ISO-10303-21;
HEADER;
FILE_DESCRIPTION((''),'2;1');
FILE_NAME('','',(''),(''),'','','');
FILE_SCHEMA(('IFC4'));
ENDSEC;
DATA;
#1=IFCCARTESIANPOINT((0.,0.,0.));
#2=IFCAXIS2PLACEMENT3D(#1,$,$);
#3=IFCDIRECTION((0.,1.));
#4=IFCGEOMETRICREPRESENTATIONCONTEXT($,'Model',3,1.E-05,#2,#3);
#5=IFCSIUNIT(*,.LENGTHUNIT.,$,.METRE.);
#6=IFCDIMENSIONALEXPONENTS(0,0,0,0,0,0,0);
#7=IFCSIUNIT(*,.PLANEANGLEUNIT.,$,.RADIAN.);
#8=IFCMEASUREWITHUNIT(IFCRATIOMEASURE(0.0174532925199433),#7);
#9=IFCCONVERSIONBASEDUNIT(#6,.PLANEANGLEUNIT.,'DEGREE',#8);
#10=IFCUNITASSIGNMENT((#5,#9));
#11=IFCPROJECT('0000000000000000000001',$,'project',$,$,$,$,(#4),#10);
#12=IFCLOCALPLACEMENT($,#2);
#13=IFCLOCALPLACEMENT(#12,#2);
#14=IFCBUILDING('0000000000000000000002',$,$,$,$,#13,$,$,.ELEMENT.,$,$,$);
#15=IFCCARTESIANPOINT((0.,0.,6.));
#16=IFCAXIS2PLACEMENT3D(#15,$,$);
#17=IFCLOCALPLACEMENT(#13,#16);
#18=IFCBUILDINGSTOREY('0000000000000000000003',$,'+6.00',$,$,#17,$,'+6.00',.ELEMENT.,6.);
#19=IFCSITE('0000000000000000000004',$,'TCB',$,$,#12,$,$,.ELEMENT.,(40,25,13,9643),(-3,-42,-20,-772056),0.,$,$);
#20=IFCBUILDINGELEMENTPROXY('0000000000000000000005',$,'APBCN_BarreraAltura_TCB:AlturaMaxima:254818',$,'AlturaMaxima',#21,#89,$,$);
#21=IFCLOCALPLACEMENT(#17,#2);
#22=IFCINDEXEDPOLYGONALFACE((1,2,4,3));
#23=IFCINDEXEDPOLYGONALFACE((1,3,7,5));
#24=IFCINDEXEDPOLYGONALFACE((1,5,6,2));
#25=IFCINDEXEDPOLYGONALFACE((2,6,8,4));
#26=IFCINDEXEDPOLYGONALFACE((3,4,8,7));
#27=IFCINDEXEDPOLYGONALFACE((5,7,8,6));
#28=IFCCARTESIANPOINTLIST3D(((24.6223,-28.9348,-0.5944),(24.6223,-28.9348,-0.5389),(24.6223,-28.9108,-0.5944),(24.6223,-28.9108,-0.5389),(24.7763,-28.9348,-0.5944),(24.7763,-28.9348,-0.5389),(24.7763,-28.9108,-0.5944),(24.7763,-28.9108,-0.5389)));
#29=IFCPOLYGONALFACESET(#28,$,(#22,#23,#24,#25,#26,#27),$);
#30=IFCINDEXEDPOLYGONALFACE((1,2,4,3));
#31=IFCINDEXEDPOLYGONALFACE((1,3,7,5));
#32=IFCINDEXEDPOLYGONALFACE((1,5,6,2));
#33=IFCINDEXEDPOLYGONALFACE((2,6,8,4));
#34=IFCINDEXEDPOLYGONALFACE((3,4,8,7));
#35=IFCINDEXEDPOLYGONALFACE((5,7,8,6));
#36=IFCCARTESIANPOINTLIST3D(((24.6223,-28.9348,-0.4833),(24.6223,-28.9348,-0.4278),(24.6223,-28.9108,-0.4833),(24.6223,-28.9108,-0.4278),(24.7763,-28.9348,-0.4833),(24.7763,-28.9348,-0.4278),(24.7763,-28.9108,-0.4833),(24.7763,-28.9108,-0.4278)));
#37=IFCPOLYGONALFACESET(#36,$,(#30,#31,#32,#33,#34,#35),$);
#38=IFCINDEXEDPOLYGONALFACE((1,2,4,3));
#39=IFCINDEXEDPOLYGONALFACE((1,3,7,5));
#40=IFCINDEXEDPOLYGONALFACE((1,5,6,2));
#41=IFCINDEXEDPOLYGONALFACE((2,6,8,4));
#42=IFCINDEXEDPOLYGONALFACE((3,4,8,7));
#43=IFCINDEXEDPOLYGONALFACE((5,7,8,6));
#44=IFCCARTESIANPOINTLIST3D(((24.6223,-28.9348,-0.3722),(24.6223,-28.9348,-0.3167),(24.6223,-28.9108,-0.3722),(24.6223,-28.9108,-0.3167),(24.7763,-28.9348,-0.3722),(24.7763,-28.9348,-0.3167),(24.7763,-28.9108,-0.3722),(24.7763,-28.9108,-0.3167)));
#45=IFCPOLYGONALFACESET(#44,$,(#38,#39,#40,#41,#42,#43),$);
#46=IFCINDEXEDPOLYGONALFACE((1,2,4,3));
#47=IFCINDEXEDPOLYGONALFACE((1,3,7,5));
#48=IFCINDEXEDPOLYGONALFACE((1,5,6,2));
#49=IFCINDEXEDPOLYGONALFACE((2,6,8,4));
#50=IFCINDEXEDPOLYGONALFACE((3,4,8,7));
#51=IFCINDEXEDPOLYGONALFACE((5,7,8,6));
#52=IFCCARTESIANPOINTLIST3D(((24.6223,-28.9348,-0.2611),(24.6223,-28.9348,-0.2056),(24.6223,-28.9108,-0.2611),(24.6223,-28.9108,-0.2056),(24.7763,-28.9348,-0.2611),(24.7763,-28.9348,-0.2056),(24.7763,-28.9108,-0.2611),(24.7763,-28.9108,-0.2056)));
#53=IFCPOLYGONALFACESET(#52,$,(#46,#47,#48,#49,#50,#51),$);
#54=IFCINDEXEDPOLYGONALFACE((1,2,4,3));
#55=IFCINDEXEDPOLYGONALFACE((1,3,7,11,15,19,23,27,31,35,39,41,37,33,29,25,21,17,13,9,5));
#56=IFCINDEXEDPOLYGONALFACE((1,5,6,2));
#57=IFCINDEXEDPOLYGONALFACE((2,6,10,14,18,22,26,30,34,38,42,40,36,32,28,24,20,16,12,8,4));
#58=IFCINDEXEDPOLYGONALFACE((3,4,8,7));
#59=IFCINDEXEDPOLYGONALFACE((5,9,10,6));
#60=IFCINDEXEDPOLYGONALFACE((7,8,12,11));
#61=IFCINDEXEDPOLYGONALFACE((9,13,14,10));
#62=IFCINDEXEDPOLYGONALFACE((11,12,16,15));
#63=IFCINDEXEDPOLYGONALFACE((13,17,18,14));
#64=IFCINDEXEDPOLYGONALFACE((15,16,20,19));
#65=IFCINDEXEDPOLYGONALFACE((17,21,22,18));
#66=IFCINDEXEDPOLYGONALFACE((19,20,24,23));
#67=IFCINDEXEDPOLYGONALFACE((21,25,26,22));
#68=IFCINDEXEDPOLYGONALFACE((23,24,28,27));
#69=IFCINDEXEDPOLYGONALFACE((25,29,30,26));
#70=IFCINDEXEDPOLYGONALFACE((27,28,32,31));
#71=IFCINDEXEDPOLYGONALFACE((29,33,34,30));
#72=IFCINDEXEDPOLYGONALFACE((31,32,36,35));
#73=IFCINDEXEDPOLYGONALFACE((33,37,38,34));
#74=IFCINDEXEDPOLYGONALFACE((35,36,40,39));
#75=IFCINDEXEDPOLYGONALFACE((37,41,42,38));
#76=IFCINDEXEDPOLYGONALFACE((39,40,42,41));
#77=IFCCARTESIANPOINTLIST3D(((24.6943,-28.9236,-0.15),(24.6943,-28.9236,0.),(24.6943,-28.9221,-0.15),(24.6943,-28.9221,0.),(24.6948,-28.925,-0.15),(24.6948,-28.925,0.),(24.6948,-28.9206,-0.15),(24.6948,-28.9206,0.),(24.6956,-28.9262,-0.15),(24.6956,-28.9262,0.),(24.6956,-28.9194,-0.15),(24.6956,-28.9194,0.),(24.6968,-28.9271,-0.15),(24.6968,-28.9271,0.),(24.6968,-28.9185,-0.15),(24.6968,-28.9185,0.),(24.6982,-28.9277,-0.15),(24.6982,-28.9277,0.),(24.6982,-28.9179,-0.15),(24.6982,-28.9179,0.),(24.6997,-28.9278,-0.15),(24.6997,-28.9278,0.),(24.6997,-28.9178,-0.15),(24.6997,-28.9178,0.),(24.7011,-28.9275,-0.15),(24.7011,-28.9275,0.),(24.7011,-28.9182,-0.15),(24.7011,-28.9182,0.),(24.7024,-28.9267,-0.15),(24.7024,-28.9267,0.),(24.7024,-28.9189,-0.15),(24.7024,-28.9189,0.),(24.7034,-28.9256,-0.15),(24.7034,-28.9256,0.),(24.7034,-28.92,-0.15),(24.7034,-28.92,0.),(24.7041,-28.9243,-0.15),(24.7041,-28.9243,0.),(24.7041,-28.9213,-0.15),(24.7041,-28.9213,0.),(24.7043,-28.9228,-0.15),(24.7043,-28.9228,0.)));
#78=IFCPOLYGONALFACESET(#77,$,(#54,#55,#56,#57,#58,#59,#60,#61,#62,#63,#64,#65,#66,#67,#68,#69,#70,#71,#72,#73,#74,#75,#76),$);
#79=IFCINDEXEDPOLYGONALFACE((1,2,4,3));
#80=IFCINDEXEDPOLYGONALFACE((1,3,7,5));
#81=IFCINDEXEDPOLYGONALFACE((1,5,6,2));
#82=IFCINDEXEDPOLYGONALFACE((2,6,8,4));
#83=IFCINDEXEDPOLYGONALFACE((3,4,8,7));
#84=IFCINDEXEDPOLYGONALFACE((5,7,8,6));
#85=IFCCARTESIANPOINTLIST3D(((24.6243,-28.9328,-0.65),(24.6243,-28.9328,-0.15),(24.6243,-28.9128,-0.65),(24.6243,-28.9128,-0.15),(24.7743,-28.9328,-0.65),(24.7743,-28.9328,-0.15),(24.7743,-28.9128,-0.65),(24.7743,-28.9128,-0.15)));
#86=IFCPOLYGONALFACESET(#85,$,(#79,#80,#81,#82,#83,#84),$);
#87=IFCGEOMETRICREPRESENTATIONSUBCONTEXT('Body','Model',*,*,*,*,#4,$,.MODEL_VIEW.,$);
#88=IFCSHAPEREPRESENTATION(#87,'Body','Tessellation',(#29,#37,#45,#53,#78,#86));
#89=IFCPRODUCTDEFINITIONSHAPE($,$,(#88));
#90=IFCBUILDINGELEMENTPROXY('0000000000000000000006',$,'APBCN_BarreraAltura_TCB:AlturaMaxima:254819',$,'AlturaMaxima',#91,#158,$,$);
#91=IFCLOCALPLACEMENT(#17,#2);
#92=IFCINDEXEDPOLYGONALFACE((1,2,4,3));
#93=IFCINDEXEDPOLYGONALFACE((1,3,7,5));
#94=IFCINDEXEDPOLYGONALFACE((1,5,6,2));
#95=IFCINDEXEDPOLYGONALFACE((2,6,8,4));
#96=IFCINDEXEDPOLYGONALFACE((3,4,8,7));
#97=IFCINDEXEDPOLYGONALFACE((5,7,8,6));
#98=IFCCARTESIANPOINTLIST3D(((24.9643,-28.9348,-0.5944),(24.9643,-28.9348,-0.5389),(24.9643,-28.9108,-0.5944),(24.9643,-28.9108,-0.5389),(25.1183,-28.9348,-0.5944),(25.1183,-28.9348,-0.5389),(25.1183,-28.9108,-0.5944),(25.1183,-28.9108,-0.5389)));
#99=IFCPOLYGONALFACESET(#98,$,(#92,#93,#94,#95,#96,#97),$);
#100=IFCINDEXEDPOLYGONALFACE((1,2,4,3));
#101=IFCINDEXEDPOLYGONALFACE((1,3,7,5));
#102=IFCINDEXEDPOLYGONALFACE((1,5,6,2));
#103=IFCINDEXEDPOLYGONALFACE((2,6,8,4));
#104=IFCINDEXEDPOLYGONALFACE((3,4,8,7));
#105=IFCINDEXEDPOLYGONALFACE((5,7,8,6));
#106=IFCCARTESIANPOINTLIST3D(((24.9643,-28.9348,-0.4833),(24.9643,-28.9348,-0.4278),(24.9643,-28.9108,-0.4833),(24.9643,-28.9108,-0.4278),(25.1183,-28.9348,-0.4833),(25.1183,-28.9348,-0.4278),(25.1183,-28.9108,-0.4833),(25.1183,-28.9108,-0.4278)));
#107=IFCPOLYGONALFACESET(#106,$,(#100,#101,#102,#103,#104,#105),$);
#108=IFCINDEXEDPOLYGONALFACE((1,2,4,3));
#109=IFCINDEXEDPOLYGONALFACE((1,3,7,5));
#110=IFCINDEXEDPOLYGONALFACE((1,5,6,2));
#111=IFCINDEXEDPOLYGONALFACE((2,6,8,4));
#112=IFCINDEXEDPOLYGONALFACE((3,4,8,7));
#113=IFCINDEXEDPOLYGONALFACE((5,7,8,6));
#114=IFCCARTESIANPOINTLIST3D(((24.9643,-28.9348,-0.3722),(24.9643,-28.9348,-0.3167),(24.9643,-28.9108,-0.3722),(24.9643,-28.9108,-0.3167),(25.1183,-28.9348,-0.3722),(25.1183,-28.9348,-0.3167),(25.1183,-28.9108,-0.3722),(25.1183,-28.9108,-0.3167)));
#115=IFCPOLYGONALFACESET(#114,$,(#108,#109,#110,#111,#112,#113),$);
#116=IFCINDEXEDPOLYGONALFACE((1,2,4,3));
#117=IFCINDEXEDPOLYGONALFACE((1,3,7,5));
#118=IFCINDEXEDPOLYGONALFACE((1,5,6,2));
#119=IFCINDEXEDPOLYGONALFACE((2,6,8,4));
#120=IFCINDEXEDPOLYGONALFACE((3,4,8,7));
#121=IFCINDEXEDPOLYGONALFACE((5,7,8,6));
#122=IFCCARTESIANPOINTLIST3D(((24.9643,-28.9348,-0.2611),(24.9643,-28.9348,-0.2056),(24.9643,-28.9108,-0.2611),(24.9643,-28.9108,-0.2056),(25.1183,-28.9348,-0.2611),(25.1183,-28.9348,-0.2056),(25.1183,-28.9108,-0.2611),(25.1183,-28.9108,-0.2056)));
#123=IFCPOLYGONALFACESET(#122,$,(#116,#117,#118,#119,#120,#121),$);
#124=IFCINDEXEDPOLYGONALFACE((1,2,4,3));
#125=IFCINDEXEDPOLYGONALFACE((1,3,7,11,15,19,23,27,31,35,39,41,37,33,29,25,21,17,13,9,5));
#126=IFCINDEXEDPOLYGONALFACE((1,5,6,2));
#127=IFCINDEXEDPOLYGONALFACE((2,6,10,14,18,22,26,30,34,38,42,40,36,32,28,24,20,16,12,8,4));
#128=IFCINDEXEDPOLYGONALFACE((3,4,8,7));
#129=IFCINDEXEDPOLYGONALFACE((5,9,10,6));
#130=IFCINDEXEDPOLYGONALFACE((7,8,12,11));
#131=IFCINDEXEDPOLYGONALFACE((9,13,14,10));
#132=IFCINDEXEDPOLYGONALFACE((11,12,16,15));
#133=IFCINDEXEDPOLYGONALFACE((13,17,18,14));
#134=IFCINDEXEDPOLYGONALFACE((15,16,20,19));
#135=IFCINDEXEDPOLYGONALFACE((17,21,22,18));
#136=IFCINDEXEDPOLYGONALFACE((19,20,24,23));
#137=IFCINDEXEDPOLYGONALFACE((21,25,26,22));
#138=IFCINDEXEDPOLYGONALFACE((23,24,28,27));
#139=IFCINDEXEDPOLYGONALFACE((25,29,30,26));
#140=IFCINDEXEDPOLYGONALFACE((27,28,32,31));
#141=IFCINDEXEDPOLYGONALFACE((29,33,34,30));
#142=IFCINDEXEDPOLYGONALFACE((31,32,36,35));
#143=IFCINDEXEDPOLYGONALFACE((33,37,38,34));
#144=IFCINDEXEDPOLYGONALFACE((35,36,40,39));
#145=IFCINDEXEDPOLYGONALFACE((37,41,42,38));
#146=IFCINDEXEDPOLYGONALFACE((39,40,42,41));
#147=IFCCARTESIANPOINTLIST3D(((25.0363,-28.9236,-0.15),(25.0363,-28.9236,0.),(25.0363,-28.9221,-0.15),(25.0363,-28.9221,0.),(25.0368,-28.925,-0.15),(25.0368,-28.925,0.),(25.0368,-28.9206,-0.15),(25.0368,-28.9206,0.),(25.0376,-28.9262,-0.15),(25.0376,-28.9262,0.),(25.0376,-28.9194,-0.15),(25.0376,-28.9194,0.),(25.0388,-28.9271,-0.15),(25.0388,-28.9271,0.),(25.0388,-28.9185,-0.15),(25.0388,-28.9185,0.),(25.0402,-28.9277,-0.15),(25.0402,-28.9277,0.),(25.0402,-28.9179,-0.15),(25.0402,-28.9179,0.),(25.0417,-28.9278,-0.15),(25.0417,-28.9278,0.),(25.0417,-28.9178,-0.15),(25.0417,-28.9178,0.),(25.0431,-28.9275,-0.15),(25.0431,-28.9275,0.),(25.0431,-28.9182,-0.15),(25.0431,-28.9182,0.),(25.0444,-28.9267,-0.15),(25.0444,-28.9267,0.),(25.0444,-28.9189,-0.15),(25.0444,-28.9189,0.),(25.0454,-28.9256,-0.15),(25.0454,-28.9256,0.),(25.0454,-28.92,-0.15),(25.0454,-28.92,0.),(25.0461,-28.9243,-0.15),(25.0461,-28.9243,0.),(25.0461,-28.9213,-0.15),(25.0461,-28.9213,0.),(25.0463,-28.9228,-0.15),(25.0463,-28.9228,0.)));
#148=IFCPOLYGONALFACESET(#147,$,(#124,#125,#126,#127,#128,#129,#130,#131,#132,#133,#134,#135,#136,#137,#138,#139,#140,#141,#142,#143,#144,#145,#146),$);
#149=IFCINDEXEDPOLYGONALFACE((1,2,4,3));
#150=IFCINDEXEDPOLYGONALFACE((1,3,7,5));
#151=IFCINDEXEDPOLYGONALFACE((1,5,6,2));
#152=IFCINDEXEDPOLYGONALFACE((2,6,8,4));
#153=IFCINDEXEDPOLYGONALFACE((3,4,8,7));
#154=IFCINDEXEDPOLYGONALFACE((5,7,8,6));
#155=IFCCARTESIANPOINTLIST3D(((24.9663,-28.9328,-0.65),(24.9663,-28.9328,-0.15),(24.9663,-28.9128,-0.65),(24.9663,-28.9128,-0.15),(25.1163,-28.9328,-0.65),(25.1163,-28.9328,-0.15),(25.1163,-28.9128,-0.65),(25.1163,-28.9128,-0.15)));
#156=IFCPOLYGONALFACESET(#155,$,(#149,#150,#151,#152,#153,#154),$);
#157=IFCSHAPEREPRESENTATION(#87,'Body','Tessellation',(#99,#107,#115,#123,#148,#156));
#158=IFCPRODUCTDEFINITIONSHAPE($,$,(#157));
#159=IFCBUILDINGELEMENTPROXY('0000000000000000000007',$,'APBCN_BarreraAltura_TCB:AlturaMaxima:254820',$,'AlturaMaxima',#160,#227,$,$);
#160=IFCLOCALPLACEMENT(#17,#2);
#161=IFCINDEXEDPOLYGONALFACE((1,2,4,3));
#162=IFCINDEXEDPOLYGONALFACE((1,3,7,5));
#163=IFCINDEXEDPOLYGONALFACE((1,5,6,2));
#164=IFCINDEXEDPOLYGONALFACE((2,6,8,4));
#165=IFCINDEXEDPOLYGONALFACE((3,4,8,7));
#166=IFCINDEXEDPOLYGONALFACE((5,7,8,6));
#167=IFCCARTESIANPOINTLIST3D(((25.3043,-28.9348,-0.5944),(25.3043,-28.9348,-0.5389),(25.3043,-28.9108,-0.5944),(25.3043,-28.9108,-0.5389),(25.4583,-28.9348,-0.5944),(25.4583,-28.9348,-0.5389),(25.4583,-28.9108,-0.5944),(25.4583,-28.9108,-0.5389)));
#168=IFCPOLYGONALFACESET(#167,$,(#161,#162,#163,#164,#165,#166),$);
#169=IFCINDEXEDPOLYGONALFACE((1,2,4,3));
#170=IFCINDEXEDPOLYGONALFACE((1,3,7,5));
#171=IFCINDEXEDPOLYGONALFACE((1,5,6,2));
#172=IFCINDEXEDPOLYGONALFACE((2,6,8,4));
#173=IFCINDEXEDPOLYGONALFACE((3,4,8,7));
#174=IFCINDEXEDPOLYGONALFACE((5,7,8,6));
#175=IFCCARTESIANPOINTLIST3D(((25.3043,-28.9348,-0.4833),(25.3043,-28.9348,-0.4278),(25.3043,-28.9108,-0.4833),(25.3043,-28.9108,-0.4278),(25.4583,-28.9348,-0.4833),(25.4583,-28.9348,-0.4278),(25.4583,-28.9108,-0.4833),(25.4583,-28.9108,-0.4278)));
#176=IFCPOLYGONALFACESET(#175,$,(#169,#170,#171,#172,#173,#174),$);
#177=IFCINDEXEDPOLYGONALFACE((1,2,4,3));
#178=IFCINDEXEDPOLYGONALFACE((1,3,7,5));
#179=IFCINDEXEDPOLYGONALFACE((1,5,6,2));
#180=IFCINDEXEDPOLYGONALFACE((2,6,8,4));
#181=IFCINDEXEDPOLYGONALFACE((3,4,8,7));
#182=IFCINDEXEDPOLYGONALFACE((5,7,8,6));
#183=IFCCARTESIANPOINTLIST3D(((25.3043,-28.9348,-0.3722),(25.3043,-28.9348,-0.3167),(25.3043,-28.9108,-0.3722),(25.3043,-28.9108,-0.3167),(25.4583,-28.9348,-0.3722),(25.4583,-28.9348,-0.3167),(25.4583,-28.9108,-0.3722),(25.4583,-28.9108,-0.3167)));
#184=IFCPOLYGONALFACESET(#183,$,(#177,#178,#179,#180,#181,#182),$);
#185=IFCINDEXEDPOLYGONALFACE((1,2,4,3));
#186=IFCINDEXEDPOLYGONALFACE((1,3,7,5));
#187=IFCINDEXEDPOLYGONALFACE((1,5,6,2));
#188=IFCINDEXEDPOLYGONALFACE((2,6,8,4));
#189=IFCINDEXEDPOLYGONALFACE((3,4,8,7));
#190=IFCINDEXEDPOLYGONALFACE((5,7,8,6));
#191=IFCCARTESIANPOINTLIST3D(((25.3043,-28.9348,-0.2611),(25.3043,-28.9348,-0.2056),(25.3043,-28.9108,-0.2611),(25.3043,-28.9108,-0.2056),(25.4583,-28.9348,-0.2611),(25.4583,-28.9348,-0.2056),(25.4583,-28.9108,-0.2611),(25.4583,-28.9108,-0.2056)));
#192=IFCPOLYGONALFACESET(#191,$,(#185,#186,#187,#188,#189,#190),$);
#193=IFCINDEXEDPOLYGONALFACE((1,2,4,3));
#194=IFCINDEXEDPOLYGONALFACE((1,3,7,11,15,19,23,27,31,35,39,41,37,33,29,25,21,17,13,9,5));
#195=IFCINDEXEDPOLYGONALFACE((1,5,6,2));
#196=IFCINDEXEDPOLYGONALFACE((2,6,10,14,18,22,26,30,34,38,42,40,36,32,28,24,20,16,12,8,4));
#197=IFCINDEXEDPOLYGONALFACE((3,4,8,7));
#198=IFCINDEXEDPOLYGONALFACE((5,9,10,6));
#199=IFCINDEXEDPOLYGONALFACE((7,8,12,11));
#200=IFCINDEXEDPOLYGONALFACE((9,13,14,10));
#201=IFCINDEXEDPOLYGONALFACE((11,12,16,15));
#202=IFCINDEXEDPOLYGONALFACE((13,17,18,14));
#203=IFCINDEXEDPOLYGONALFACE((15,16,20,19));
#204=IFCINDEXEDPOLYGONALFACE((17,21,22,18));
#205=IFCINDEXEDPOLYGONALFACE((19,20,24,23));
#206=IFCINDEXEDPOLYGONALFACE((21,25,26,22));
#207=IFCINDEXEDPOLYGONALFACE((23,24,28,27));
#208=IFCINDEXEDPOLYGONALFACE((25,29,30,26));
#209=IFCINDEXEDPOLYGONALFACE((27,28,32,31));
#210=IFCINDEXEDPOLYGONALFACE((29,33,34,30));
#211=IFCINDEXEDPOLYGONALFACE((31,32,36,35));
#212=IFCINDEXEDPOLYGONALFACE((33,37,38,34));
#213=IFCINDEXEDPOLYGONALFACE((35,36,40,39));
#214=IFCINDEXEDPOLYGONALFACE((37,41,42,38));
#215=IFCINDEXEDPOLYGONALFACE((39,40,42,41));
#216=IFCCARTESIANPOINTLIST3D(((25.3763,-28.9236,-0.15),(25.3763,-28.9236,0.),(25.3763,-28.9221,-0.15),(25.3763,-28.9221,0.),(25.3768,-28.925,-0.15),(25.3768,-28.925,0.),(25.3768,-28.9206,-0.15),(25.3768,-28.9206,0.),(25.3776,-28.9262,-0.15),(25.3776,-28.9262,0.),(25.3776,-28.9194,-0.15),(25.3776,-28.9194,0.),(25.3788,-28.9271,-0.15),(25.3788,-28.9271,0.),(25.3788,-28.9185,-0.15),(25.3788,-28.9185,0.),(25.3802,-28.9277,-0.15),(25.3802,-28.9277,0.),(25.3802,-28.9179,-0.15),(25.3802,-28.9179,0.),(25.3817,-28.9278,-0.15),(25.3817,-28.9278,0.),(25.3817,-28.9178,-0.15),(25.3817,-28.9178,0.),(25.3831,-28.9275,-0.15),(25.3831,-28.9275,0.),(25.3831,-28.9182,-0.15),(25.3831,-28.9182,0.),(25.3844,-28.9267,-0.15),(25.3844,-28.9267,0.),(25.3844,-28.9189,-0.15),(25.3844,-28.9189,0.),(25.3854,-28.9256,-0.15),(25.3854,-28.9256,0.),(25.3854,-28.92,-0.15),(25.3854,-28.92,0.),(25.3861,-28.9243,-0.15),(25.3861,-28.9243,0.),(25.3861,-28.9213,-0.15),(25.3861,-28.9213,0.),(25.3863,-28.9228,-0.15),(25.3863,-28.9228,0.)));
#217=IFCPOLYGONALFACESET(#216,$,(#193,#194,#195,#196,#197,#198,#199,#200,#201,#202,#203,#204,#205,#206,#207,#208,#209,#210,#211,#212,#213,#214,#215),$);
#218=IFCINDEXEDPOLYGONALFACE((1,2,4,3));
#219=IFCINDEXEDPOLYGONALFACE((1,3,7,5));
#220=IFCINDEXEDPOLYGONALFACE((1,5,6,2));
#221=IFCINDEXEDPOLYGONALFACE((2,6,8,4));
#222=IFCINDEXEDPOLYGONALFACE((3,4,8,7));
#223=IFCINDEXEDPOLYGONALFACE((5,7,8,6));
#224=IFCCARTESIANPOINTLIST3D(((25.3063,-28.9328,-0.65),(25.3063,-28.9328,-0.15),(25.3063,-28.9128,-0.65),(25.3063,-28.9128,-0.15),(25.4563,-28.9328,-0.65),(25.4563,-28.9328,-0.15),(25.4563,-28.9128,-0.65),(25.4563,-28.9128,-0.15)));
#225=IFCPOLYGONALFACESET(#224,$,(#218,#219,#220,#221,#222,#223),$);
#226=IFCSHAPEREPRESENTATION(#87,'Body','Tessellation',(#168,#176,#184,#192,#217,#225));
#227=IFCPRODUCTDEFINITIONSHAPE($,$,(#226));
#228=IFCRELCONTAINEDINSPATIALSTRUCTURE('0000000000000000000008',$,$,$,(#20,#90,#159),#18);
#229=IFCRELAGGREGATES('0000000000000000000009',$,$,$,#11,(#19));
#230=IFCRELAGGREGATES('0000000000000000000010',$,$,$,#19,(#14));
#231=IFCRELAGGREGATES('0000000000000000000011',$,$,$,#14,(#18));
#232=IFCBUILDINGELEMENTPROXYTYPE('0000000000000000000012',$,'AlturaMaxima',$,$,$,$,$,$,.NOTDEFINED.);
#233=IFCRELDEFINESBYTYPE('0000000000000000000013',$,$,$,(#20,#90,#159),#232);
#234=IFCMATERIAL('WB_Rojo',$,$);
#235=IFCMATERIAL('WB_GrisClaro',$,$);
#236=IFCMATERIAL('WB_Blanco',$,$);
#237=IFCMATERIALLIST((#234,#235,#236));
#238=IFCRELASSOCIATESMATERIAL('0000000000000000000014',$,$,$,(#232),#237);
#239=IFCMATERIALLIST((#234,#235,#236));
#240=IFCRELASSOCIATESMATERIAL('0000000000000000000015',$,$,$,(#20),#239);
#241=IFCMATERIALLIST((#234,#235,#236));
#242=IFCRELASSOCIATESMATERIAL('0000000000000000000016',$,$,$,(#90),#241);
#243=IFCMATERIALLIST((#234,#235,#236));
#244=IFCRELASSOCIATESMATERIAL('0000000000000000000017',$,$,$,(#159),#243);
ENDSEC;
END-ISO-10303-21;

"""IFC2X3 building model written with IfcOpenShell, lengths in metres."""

from ifc_helpers import new_model, entity, si_unit, converted_unit, direction, frame, frame_2d, origin, origin_2d_with_axis, place, context, subcontext, project, spatial, rectangle, circle, extrude, source, transform, mapped, material, material_list, type_object, type_shapes, element, save


model = new_model("IFC2X3")

# Units and contexts
model_context = context("Model", 3, precision=1e-05, world=origin(), true_north=direction((0.0, 1.0)))
body_context = subcontext(model_context, "Body", "Model", "MODEL_VIEW")
ifc_project = project(units=[si_unit("LENGTHUNIT", "METRE"), converted_unit("PLANEANGLEUNIT", "DEGREE", entity("IfcRatioMeasure", 0.0174532925199433), si_unit("PLANEANGLEUNIT", "RADIAN"), dimensions=[0, 0, 0, 0, 0, 0, 0])], contexts=[model_context])

# Site, building, storey
site_placement = place(None, origin())
site = spatial("IfcSite", under=ifc_project, at=site_placement, Name="TCB", CompositionType="ELEMENT", RefLatitude=(40, 25, 13, 9643), RefLongitude=(-3, -42, -20, -772056), RefElevation=0.0)
building_placement = place(site_placement, origin())
building = spatial("IfcBuilding", under=site, at=building_placement, CompositionType="ELEMENT")
storey_placement = place(building_placement, frame((0.0, 0.0, 6.0)))
storey = spatial("IfcBuildingStorey", under=building, at=storey_placement, Name="+6.00", LongName="+6.00", CompositionType="ELEMENT", Elevation=6.0)

# Building element proxies
ifc_material_1 = material(Name="WB_Rojo")
ifc_material_2 = material(Name="WB_GrisClaro")
ifc_material_3 = material(Name="WB_Blanco")
ifc_material_list_1 = material_list([ifc_material_1, ifc_material_2, ifc_material_3])
building_element_proxy_type = type_object("IfcBuildingElementProxyType", Name="AlturaMaxima", PredefinedType="NOTDEFINED", material=ifc_material_list_1)
shared_shape = source(origin(), body_context, "Body", "SweptSolid", [
    extrude(rectangle(XDim=0.154, YDim=0.024, at=frame_2d((0.0, 0.0), x_axis=(1.0, 0.0))), frame((0.0, 0.0, -0.5944), z_axis=(0.0, 0.0, 1.0), x_axis=(-1.0, 0.0, 0.0)), (0.0, 0.0, 1.0), 0.0556),
    extrude(rectangle(XDim=0.154, YDim=0.024, at=frame_2d((0.0, 0.0), x_axis=(1.0, 0.0))), frame((0.0, 0.0, -0.4833), z_axis=(0.0, 0.0, 1.0), x_axis=(-1.0, 0.0, 0.0)), (0.0, 0.0, 1.0), 0.0556),
    extrude(rectangle(XDim=0.154, YDim=0.024, at=frame_2d((0.0, 0.0), x_axis=(1.0, 0.0))), frame((0.0, 0.0, -0.3722), z_axis=(0.0, 0.0, 1.0), x_axis=(-1.0, 0.0, 0.0)), (0.0, 0.0, 1.0), 0.0556),
    extrude(rectangle(XDim=0.154, YDim=0.024, at=frame_2d((0.0, 0.0), x_axis=(1.0, 0.0))), frame((0.0, 0.0, -0.2611), z_axis=(0.0, 0.0, 1.0), x_axis=(-1.0, 0.0, 0.0)), (0.0, 0.0, 1.0), 0.0556),
    extrude(circle(Radius=0.005, at=frame_2d((0.0, 0.0), x_axis=(1.0, 0.0))), frame((0.0, 0.0, -0.15)), (0.0, 0.0, 1.0), 0.15),
    extrude(rectangle(XDim=0.02, YDim=0.15, at=origin_2d_with_axis()), frame((0.0, 0.0, -0.65), z_axis=(0.0, 0.0, 1.0), x_axis=(0.0, 1.0, 0.0)), (0.0, 0.0, 1.0), 0.5),
])
type_shapes(building_element_proxy_type, [shared_shape])
ifc_material_list_2 = material_list([ifc_material_1, ifc_material_2, ifc_material_3])
proxy_1_placement = place(storey_placement, frame((24.6993, -28.9228, 0.0)))
element("IfcBuildingElementProxy", 1, at=proxy_1_placement, inside=storey, type_object=building_element_proxy_type, material=ifc_material_list_2, Name="APBCN_BarreraAltura_TCB:AlturaMaxima:254818", ObjectType="AlturaMaxima", context=body_context, shape_type="MappedRepresentation", body=[
    mapped(shared_shape, transform((0.0, 0.0, 0.0), scale=1.0)),
])
ifc_material_list_3 = material_list([ifc_material_1, ifc_material_2, ifc_material_3])
proxy_2_placement = place(storey_placement, frame((25.0413, -28.9228, 0.0)))
element("IfcBuildingElementProxy", 2, at=proxy_2_placement, inside=storey, type_object=building_element_proxy_type, material=ifc_material_list_3, Name="APBCN_BarreraAltura_TCB:AlturaMaxima:254819", ObjectType="AlturaMaxima", context=body_context, shape_type="MappedRepresentation", body=[
    mapped(shared_shape, transform((0.0, 0.0, 0.0), scale=1.0)),
])
ifc_material_list_4 = material_list([ifc_material_1, ifc_material_2, ifc_material_3])
proxy_3_placement = place(storey_placement, frame((25.3813, -28.9228, 0.0)))
element("IfcBuildingElementProxy", 3, at=proxy_3_placement, inside=storey, type_object=building_element_proxy_type, material=ifc_material_list_4, Name="APBCN_BarreraAltura_TCB:AlturaMaxima:254820", ObjectType="AlturaMaxima", context=body_context, shape_type="MappedRepresentation", body=[
    mapped(shared_shape, transform((0.0, 0.0, 0.0), scale=1.0)),
])

save(model, "model.ifc")
